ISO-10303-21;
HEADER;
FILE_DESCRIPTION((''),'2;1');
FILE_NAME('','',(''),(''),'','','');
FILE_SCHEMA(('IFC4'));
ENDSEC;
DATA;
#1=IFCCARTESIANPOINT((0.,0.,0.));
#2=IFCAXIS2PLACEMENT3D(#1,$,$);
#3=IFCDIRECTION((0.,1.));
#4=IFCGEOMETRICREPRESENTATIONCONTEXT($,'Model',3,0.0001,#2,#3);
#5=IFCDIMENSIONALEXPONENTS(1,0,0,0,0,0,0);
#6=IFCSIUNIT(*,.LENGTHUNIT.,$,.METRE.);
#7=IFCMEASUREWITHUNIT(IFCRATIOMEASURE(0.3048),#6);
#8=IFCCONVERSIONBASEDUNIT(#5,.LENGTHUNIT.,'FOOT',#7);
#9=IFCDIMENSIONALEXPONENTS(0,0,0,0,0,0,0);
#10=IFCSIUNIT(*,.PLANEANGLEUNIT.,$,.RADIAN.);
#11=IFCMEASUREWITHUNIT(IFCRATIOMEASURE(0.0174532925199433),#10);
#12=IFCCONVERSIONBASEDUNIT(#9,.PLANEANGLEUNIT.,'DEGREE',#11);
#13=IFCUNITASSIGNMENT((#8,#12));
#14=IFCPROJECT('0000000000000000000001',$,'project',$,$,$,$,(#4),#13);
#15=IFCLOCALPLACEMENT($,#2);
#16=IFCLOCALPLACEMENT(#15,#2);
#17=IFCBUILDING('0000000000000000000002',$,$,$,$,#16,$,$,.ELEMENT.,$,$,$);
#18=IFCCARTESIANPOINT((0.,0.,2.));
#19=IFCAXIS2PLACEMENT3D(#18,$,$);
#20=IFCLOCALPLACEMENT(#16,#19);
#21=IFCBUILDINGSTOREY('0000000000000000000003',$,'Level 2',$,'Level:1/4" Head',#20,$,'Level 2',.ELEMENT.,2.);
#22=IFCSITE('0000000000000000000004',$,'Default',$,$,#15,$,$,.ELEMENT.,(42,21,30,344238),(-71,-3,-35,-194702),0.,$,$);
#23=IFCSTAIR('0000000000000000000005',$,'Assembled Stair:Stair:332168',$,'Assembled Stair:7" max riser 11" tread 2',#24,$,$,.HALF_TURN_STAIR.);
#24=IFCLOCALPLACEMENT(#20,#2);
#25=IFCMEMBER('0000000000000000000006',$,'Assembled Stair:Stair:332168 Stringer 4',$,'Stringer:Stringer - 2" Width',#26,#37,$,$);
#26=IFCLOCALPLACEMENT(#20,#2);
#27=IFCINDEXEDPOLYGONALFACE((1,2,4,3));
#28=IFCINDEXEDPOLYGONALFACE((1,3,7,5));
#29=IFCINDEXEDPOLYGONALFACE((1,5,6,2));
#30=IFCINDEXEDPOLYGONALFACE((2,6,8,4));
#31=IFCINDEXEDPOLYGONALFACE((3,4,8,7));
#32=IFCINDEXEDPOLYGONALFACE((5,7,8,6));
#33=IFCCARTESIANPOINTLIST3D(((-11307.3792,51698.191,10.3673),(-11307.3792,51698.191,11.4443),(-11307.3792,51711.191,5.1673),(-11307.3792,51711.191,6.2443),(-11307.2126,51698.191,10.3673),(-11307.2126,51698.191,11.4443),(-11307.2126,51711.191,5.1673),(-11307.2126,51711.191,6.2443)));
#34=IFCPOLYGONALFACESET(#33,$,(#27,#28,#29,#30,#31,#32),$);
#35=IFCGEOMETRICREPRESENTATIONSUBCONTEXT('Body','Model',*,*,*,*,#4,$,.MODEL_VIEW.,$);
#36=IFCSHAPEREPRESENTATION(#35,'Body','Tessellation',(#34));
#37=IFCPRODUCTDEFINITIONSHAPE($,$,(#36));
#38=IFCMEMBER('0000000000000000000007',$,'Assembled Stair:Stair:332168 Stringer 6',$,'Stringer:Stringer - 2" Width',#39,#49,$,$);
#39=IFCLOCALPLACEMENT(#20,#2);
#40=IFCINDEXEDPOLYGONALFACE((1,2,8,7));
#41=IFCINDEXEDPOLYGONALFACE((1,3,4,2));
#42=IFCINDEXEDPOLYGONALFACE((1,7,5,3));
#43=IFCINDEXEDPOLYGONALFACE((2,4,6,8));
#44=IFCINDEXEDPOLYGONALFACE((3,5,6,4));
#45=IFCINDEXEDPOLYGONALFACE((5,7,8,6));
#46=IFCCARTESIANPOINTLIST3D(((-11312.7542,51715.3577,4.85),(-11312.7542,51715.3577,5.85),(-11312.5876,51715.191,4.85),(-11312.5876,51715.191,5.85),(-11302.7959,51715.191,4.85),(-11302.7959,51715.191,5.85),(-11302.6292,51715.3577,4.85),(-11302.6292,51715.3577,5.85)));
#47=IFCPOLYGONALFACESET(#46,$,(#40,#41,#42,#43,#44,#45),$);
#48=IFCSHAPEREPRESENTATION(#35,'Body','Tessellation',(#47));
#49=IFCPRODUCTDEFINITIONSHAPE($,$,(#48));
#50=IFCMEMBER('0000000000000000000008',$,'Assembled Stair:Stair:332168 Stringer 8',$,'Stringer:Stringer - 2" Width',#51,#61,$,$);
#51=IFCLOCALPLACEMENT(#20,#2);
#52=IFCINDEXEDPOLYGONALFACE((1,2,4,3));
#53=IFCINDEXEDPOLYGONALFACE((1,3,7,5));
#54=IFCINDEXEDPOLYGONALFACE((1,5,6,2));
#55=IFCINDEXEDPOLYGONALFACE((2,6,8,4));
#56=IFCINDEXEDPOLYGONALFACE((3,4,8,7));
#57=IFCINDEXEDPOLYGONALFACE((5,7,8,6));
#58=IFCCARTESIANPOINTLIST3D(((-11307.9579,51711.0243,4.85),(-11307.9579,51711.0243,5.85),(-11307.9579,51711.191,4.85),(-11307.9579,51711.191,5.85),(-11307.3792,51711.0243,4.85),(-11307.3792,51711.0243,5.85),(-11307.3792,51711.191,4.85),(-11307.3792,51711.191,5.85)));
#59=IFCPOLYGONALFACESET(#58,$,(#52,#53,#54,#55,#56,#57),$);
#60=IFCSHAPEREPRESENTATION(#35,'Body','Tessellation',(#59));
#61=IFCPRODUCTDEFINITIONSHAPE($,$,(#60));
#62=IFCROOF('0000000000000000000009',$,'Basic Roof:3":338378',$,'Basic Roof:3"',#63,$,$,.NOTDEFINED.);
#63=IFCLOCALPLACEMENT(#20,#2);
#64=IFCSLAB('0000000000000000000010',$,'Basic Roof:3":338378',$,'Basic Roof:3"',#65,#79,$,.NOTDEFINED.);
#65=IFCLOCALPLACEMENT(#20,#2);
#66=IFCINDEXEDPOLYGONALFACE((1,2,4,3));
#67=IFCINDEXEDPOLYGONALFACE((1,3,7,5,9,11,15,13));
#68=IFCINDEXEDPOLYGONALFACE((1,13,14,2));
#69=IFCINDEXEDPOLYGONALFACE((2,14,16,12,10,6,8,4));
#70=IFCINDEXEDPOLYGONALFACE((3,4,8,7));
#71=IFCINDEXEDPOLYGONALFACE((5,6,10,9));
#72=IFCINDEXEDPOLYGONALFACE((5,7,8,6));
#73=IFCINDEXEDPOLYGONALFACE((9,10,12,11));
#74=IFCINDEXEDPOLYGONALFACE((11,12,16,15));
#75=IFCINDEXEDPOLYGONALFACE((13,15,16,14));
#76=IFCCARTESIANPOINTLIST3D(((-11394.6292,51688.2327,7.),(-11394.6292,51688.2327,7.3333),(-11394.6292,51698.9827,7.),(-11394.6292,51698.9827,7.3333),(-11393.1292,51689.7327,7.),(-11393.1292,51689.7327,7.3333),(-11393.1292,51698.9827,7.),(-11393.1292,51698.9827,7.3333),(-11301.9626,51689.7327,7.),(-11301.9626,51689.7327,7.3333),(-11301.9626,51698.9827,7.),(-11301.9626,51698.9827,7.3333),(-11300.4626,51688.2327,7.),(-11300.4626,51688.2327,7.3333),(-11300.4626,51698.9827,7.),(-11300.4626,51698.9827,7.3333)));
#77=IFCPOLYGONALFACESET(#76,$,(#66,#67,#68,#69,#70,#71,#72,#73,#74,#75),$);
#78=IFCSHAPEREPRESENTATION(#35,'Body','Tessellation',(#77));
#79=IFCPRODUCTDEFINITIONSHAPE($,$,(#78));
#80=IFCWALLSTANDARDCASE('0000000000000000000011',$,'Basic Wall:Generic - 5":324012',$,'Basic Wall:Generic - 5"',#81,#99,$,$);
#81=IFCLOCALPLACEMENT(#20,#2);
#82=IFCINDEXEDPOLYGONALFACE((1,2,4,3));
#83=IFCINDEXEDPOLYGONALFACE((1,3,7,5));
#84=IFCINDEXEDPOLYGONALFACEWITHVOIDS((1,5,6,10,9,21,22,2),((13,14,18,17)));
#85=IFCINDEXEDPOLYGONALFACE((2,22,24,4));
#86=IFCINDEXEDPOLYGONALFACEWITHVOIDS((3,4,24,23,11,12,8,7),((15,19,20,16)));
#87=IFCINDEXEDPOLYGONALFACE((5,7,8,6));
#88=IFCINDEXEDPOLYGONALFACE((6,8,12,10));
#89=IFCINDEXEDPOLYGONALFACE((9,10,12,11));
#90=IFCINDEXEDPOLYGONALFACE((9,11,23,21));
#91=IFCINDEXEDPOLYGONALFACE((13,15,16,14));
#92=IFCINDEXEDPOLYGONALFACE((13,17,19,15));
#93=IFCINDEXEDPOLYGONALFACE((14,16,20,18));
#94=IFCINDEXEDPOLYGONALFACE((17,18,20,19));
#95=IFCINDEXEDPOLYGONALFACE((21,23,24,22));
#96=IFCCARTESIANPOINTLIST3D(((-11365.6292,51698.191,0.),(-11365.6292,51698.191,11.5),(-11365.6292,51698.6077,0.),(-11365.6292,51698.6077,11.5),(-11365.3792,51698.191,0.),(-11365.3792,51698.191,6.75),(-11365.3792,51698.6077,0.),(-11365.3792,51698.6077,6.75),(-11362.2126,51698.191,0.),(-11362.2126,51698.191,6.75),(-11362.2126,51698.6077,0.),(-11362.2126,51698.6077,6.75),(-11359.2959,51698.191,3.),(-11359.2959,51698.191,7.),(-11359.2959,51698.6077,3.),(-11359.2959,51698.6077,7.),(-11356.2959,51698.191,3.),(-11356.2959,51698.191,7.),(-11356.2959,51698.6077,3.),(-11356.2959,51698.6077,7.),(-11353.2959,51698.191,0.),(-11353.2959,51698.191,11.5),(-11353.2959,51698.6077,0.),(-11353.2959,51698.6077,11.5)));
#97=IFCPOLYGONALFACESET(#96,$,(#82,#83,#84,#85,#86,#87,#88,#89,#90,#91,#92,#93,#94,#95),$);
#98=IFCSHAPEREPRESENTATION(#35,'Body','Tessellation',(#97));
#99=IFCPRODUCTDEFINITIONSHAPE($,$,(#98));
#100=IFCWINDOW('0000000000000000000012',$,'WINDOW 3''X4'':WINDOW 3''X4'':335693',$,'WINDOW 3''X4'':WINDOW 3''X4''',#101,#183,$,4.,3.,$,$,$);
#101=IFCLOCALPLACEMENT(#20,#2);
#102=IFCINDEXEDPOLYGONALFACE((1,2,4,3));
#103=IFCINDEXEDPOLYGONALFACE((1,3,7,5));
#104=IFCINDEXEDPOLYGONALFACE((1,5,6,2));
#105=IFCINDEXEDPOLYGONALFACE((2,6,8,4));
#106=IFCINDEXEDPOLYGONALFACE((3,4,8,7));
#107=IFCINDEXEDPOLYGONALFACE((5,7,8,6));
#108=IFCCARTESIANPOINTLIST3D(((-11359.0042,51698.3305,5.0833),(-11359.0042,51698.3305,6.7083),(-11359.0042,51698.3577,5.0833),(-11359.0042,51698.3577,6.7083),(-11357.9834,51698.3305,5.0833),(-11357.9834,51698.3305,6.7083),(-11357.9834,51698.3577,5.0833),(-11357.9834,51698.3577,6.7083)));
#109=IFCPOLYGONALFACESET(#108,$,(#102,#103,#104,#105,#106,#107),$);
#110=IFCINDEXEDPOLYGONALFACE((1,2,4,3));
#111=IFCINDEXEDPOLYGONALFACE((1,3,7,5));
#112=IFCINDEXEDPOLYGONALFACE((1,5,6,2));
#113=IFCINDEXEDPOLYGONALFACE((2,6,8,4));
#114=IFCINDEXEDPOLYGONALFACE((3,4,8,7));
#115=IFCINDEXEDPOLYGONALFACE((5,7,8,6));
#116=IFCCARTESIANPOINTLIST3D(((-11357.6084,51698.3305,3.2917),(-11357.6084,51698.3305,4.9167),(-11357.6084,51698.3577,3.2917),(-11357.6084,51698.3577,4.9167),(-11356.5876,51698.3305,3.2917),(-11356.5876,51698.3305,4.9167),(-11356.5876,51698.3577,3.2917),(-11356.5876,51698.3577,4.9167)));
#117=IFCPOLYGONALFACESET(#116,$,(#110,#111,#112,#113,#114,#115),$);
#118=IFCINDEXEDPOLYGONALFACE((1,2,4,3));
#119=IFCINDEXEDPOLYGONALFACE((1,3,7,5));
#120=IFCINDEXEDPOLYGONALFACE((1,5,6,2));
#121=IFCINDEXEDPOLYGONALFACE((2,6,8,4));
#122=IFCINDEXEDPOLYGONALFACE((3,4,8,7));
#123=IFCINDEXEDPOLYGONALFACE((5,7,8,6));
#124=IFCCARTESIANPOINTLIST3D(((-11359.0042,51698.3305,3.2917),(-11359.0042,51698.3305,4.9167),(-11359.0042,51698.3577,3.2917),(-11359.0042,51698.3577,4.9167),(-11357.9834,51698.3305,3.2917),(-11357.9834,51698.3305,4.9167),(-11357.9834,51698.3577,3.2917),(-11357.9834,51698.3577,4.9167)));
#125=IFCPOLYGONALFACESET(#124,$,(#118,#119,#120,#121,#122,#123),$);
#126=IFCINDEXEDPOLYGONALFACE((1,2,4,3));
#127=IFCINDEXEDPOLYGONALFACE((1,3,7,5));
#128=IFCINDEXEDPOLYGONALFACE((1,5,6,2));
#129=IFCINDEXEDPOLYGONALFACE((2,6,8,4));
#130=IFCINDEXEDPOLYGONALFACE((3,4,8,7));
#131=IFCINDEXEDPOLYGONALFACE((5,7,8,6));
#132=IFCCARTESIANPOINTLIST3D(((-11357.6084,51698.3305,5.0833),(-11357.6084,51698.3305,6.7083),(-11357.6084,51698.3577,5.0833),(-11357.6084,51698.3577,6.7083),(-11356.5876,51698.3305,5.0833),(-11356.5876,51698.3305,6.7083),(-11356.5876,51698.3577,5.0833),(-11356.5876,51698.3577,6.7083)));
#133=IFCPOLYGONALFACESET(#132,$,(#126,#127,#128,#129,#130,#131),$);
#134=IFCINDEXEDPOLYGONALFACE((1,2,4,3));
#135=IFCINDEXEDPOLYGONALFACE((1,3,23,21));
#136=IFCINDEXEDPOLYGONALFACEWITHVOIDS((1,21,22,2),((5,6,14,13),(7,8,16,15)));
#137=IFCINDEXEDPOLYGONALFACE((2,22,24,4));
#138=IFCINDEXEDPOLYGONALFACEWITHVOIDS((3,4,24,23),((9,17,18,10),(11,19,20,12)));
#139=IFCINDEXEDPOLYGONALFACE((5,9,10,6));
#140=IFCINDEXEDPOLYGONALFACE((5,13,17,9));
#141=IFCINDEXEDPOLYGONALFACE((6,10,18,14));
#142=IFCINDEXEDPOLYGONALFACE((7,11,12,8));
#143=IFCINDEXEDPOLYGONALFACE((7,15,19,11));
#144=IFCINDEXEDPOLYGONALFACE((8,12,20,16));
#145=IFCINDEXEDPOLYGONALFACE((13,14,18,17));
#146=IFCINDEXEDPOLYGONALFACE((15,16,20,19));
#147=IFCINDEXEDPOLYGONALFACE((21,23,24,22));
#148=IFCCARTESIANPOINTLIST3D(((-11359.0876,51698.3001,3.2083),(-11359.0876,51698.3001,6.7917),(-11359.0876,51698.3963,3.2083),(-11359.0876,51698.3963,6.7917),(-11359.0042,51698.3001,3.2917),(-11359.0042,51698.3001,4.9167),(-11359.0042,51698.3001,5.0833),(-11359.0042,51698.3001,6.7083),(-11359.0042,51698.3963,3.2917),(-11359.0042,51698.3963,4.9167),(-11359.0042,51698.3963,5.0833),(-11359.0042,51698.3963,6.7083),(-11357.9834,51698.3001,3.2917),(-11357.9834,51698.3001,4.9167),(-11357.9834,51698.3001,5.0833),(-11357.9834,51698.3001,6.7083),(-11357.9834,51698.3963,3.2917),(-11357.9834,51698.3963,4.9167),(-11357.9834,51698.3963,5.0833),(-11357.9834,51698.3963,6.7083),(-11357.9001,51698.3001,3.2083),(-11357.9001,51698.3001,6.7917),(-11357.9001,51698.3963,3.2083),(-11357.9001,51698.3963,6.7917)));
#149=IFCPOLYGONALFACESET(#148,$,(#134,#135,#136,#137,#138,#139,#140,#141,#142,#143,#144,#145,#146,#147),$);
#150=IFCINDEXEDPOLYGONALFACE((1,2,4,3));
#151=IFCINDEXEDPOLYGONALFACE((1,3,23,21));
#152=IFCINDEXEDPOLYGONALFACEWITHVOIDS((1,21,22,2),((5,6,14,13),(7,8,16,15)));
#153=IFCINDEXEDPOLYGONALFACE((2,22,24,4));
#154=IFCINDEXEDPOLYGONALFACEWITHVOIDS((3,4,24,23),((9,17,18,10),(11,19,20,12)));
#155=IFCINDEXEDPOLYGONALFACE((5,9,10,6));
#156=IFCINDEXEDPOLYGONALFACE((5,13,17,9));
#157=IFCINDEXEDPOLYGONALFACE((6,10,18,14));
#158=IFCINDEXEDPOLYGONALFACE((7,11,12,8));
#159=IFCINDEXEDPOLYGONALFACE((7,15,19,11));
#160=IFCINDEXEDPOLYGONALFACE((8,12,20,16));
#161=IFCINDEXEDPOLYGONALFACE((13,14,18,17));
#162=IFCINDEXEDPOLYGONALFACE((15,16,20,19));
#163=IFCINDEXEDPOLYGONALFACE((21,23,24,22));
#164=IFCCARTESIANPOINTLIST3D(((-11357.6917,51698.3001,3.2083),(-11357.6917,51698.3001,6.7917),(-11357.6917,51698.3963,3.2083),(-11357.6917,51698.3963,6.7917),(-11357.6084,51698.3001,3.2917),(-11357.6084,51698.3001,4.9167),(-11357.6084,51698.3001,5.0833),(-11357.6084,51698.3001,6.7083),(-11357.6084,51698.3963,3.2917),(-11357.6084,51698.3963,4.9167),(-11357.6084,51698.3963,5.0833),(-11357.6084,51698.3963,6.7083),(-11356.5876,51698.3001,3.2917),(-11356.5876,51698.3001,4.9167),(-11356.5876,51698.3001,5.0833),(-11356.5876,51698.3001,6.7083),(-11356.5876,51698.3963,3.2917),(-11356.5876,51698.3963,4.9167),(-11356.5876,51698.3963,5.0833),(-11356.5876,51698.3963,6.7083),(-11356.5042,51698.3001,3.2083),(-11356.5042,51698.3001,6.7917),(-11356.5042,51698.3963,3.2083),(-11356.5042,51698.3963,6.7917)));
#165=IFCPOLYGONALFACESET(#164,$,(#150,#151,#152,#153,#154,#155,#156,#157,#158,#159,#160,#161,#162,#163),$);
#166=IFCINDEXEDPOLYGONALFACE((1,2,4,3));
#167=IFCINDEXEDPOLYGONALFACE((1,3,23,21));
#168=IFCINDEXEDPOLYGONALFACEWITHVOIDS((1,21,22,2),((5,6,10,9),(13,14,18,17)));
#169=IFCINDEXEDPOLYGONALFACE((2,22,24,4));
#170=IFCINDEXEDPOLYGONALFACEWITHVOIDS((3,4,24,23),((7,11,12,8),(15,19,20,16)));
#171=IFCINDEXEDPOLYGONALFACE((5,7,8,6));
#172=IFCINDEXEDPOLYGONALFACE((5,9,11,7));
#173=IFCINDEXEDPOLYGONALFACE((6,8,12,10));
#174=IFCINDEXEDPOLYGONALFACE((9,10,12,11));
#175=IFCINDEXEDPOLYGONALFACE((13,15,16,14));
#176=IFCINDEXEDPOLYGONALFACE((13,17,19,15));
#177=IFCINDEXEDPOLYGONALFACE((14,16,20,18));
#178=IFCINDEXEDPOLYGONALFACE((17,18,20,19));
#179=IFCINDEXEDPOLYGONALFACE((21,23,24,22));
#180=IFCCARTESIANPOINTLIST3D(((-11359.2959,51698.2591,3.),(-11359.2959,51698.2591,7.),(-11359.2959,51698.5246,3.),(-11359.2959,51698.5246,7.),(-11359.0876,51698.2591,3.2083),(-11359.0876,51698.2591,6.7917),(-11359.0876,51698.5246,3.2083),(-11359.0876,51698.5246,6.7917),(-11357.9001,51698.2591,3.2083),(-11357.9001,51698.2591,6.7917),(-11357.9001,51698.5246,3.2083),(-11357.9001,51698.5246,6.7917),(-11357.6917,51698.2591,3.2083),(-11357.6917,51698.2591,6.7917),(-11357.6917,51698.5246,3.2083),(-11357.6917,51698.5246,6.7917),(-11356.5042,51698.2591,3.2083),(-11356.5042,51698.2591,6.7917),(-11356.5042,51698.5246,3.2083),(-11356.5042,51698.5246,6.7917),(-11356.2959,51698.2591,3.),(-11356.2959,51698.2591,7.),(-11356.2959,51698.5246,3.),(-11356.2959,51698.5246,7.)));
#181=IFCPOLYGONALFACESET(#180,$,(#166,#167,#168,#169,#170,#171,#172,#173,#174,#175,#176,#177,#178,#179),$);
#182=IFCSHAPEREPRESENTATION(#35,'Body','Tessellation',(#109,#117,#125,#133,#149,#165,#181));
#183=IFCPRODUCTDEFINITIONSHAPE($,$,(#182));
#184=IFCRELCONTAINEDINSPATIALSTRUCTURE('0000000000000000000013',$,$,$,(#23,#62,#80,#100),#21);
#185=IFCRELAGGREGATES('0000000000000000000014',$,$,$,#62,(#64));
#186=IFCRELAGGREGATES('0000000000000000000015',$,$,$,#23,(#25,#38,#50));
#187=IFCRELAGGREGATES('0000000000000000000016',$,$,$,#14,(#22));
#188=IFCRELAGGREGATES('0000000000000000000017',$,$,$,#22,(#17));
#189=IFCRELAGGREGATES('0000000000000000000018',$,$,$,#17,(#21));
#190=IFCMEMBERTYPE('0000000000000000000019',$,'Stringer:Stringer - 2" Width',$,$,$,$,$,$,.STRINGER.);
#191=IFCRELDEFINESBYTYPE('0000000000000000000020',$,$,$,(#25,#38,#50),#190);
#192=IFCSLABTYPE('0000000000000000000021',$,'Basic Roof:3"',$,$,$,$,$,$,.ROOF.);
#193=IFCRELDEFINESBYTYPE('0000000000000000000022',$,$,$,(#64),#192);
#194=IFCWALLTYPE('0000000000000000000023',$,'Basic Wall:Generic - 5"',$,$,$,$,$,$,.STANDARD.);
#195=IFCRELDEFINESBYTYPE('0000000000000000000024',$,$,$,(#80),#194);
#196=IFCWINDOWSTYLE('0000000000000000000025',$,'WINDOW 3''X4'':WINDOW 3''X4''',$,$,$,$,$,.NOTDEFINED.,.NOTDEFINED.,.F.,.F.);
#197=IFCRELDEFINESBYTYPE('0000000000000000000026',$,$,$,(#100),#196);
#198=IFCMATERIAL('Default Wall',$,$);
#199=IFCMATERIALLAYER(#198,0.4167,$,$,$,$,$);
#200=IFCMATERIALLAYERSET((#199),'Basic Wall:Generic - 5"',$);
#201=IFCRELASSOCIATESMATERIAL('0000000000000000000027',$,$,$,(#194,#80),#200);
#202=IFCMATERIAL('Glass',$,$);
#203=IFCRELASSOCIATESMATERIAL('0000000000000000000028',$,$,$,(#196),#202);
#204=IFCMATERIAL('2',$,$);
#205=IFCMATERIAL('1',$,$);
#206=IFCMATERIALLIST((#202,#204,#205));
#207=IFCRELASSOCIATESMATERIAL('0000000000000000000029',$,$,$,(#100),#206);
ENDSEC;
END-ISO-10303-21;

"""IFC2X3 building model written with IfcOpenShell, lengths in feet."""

from ifc_helpers import new_model, entity, si_unit, converted_unit, direction, frame, frame_2d, origin, origin_2d_with_axis, place, context, subcontext, project, spatial, polyline, rectangle, outline, extrude, source, transform, mapped, material, material_list, layer, layer_set, layer_usage, type_object, type_shapes, element, fill, aggregate, save


model = new_model("IFC2X3")

# Units and contexts
model_context = context("Model", 3, precision=0.0001, world=origin(), true_north=direction((0.0, 1.0)))
body_context = subcontext(model_context, "Body", "Model", "MODEL_VIEW")
ifc_project = project(units=[converted_unit("LENGTHUNIT", "FOOT", entity("IfcRatioMeasure", 0.3048), si_unit("LENGTHUNIT", "METRE"), dimensions=[1, 0, 0, 0, 0, 0, 0]), converted_unit("PLANEANGLEUNIT", "DEGREE", entity("IfcRatioMeasure", 0.0174532925199433), si_unit("PLANEANGLEUNIT", "RADIAN"), dimensions=[0, 0, 0, 0, 0, 0, 0])], contexts=[model_context])

# Site, building, storey
site_placement = place(None, origin())
site = spatial("IfcSite", under=ifc_project, at=site_placement, Name="Default", CompositionType="ELEMENT", RefLatitude=(42, 21, 30, 344238), RefLongitude=(-71, -3, -35, -194702), RefElevation=0.0)
building_placement = place(site_placement, origin())
building = spatial("IfcBuilding", under=site, at=building_placement, CompositionType="ELEMENT")
storey_placement = place(building_placement, frame((0.0, 0.0, 2.0)))
storey = spatial("IfcBuildingStorey", under=building, at=storey_placement, Name="Level 2", ObjectType="Level:1/4\" Head", LongName="Level 2", CompositionType="ELEMENT", Elevation=2.0)

# Stair, members
stair_placement = place(storey_placement, origin())
stair = element("IfcStair", 1, at=stair_placement, inside=storey, Name="Assembled Stair:Stair:332168", ObjectType="Assembled Stair:7\" max riser 11\" tread 2", ShapeType="HALF_TURN_STAIR")
member_type = type_object("IfcMemberType", Name="Stringer:Stringer - 2\" Width", PredefinedType="STRINGER")
member_1_placement = place(stair_placement, origin())
member_1 = element("IfcMember", 2, at=member_1_placement, type_object=member_type, Name="Assembled Stair:Stair:332168 Stringer 4", ObjectType="Stringer:Stringer - 2\" Width", context=body_context, shape_type="SweptSolid", body=[
    extrude(outline(polyline([(-6.8007, -0.5), (7.2007, -0.5), (6.8007, 0.5), (-7.2007, 0.5), (-6.8007, -0.5)])), frame((-11307.3792, 51704.691, 8.3058), z_axis=(1.0, 0.0, 0.0), x_axis=(0.0, -0.928477, 0.371391)), (0.0, 0.0, 1.0), 0.1667),
])
member_2_placement = place(stair_placement, origin())
member_2 = element("IfcMember", 3, at=member_2_placement, type_object=member_type, Name="Assembled Stair:Stair:332168 Stringer 6", ObjectType="Stringer:Stringer - 2\" Width", context=body_context, shape_type="SweptSolid", body=[
    extrude(outline(polyline([(-5.0625, -0.0833), (5.0625, -0.0833), (4.8958, 0.0833), (-4.8958, 0.0833), (-5.0625, -0.0833)])), frame((-11307.6917, 51715.2743, 4.85), z_axis=(0.0, 0.0, 1.0), x_axis=(-1.0, 0.0, 0.0)), (0.0, 0.0, 1.0), 1.0),
])
member_3_placement = place(stair_placement, origin())
member_3 = element("IfcMember", 4, at=member_3_placement, type_object=member_type, Name="Assembled Stair:Stair:332168 Stringer 8", ObjectType="Stringer:Stringer - 2\" Width", context=body_context, shape_type="SweptSolid", body=[
    extrude(rectangle(XDim=0.5786, YDim=0.1667, at=frame_2d((0.0, 0.0), x_axis=(1.0, 0.0))), frame((-11307.6686, 51711.1077, 4.85)), (0.0, 0.0, 1.0), 1.0),
])

# Roof, slab
roof_placement = place(storey_placement, frame((-11394.6292, 51688.2327, 7.0)))
roof = element("IfcRoof", 5, at=roof_placement, inside=storey, Name="Basic Roof:3\":338378", ObjectType="Basic Roof:3\"", ShapeType="NOTDEFINED")
slab_type_1 = type_object("IfcSlabType", Name="Basic Roof:3\"", PredefinedType="ROOF")
slab_1_placement = place(roof_placement, origin())
slab_1 = element("IfcSlab", 6, at=slab_1_placement, type_object=slab_type_1, Name="Basic Roof:3\":338378", ObjectType="Basic Roof:3\"", PredefinedType="NOTDEFINED", context=body_context, shape_type="SweptSolid", body=[
    extrude(outline(polyline([(45.5833, -3.875), (-45.5833, -3.875), (-45.5833, 5.375), (-47.0833, 5.375), (-47.0833, -5.375), (47.0833, -5.375), (47.0833, 5.375), (45.5833, 5.375), (45.5833, -3.875)])), frame((47.0833, 5.375, 0.0)), (0.0, 0.0, 1.0), 0.3333),
])
aggregate(roof, [slab_1])

# Wall, openings, window
ifc_material_1 = material(Name="Default Wall")
ifc_layer_1 = layer(ifc_material_1, 0.4167)
ifc_layer_set_1 = layer_set([ifc_layer_1], Name="Basic Wall:Generic - 5\"")
ifc_layer_usage_1 = layer_usage(ifc_layer_set_1, "AXIS2", "NEGATIVE", 0.2083)
wall_type = type_object("IfcWallType", Name="Basic Wall:Generic - 5\"", PredefinedType="STANDARD", material=ifc_layer_set_1)
wall_1_placement = place(storey_placement, frame((-11365.6292, 51698.3993, 0.0)))
wall_1 = element("IfcWallStandardCase", 7, at=wall_1_placement, inside=storey, type_object=wall_type, material=ifc_layer_usage_1, Name="Basic Wall:Generic - 5\":324012", ObjectType="Basic Wall:Generic - 5\"", context=body_context, shape_type="SweptSolid", body=[
    extrude(rectangle(XDim=12.3333, YDim=0.4167, at=frame_2d((6.1667, 0.0), x_axis=(-1.0, 0.0))), origin(), (0.0, 0.0, 1.0), 11.5),
])
opening_1_placement = place(wall_1_placement, frame((0.25, -0.2083, 0.0)))
element("IfcOpeningElement", 8, at=opening_1_placement, cuts=wall_1, ObjectType="Opening", context=body_context, shape_type="SweptSolid", body=[
    extrude(rectangle(XDim=6.75, YDim=3.1667, at=frame_2d((3.375, 1.5833), x_axis=(1.0, 0.0))), frame((0.0, 0.0, 0.0), z_axis=(0.0, 1.0, 0.0), x_axis=(0.0, 0.0, 1.0)), (0.0, 0.0, 1.0), 0.4167),
])
opening_2_placement = place(wall_1_placement, frame((9.3333, 0.2083, 3.0)))
opening_2 = element("IfcOpeningElement", 9, at=opening_2_placement, cuts=wall_1, ObjectType="Opening", context=body_context, shape_type="SweptSolid", body=[
    extrude(rectangle(XDim=4.0, YDim=3.0, at=frame_2d((2.0, 1.5), x_axis=(-1.0, 0.0))), frame((0.0, 0.0, 0.0), z_axis=(0.0, -1.0, 0.0), x_axis=(0.0, 0.0, 1.0)), (0.0, 0.0, 1.0), 0.4167),
])
ifc_material_2 = material(Name="Glass")
ifc_material_3 = material(Name="2")
ifc_material_4 = material(Name="1")
ifc_material_list_1 = material_list([ifc_material_2, ifc_material_3, ifc_material_4])
window_style = type_object("IfcWindowStyle", Name="WINDOW 3'X4':WINDOW 3'X4'", ConstructionType="NOTDEFINED", OperationType="NOTDEFINED", ParameterTakesPrecedence=False, Sizeable=False, material=ifc_material_2)
shared_shape = source(origin(), body_context, "Body", "SweptSolid", [
    extrude(rectangle(XDim=0.0272, YDim=1.0208, at=origin_2d_with_axis()), frame((2.1979, 0.2636, 2.0833), z_axis=(0.0, 0.0, 1.0), x_axis=(0.0, 1.0, 0.0)), (0.0, 0.0, 1.0), 1.625),
    extrude(rectangle(XDim=0.0272, YDim=1.0208, at=origin_2d_with_axis()), frame((0.8021, 0.2636, 0.2917), z_axis=(0.0, 0.0, 1.0), x_axis=(0.0, 1.0, 0.0)), (0.0, 0.0, 1.0), 1.625),
    extrude(rectangle(XDim=0.0272, YDim=1.0208, at=origin_2d_with_axis()), frame((2.1979, 0.2636, 0.2917), z_axis=(0.0, 0.0, 1.0), x_axis=(0.0, 1.0, 0.0)), (0.0, 0.0, 1.0), 1.625),
    extrude(rectangle(XDim=0.0272, YDim=1.0208, at=origin_2d_with_axis()), frame((0.8021, 0.2636, 2.0833), z_axis=(0.0, 0.0, 1.0), x_axis=(0.0, 1.0, 0.0)), (0.0, 0.0, 1.0), 1.625),
    extrude(outline(polyline([(-0.5938, -1.7917), (0.5938, -1.7917), (0.5938, 1.7917), (-0.5938, 1.7917), (-0.5938, -1.7917)]), holes=[polyline([(-0.5104, -0.0833), (0.5104, -0.0833), (0.5104, -1.7083), (-0.5104, -1.7083), (-0.5104, -0.0833)]), polyline([(-0.5104, 1.7083), (0.5104, 1.7083), (0.5104, 0.0833), (-0.5104, 0.0833), (-0.5104, 1.7083)])]), frame((2.1979, 0.2114, 2.0), z_axis=(0.0, 1.0, 0.0), x_axis=(-1.0, 0.0, 0.0)), (0.0, 0.0, 1.0), 0.0962),
    extrude(outline(polyline([(-1.7917, -0.5937), (1.7917, -0.5937), (1.7917, 0.5937), (-1.7917, 0.5937), (-1.7917, -0.5937)]), holes=[polyline([(0.0833, -0.5104), (0.0833, 0.5104), (1.7083, 0.5104), (1.7083, -0.5104), (0.0833, -0.5104)]), polyline([(-1.7083, -0.5104), (-1.7083, 0.5104), (-0.0833, 0.5104), (-0.0833, -0.5104), (-1.7083, -0.5104)])]), frame((0.8021, 0.2114, 2.0), z_axis=(0.0, 1.0, 0.0), x_axis=(0.0, 0.0, -1.0)), (0.0, 0.0, 1.0), 0.0962),
    extrude(outline(polyline([(-1.5, -2.0), (1.5, -2.0), (1.5, 2.0), (-1.5, 2.0), (-1.5, -2.0)]), holes=[polyline([(-0.1042, 1.7917), (-0.1042, -1.7917), (-1.2917, -1.7917), (-1.2917, 1.7917), (-0.1042, 1.7917)]), polyline([(0.1042, -1.7917), (0.1042, 1.7917), (1.2917, 1.7917), (1.2917, -1.7917), (0.1042, -1.7917)])]), frame((1.5, 0.0831, 2.0), z_axis=(0.0, 1.0, 0.0), x_axis=(1.0, 0.0, 0.0)), (0.0, 0.0, 1.0), 0.2655),
])
type_shapes(window_style, [shared_shape])
window_1_placement = place(opening_2_placement, frame((0.0, 0.0, 0.0), z_axis=(0.0, 0.0, 1.0), x_axis=(-1.0, 0.0, 0.0)))
window_1 = element("IfcWindow", 10, at=window_1_placement, inside=storey, type_object=window_style, material=ifc_material_list_1, Name="WINDOW 3'X4':WINDOW 3'X4':335693", ObjectType="WINDOW 3'X4':WINDOW 3'X4'", OverallHeight=4.0, OverallWidth=3.0, context=body_context, shape_type="MappedRepresentation", body=[
    mapped(shared_shape, transform((0.0, 0.0, 0.0), scale=1.0)),
])
fill(opening_2, window_1)

aggregate(stair, [member_1, member_2, member_3])

save(model, "model.ifc")
